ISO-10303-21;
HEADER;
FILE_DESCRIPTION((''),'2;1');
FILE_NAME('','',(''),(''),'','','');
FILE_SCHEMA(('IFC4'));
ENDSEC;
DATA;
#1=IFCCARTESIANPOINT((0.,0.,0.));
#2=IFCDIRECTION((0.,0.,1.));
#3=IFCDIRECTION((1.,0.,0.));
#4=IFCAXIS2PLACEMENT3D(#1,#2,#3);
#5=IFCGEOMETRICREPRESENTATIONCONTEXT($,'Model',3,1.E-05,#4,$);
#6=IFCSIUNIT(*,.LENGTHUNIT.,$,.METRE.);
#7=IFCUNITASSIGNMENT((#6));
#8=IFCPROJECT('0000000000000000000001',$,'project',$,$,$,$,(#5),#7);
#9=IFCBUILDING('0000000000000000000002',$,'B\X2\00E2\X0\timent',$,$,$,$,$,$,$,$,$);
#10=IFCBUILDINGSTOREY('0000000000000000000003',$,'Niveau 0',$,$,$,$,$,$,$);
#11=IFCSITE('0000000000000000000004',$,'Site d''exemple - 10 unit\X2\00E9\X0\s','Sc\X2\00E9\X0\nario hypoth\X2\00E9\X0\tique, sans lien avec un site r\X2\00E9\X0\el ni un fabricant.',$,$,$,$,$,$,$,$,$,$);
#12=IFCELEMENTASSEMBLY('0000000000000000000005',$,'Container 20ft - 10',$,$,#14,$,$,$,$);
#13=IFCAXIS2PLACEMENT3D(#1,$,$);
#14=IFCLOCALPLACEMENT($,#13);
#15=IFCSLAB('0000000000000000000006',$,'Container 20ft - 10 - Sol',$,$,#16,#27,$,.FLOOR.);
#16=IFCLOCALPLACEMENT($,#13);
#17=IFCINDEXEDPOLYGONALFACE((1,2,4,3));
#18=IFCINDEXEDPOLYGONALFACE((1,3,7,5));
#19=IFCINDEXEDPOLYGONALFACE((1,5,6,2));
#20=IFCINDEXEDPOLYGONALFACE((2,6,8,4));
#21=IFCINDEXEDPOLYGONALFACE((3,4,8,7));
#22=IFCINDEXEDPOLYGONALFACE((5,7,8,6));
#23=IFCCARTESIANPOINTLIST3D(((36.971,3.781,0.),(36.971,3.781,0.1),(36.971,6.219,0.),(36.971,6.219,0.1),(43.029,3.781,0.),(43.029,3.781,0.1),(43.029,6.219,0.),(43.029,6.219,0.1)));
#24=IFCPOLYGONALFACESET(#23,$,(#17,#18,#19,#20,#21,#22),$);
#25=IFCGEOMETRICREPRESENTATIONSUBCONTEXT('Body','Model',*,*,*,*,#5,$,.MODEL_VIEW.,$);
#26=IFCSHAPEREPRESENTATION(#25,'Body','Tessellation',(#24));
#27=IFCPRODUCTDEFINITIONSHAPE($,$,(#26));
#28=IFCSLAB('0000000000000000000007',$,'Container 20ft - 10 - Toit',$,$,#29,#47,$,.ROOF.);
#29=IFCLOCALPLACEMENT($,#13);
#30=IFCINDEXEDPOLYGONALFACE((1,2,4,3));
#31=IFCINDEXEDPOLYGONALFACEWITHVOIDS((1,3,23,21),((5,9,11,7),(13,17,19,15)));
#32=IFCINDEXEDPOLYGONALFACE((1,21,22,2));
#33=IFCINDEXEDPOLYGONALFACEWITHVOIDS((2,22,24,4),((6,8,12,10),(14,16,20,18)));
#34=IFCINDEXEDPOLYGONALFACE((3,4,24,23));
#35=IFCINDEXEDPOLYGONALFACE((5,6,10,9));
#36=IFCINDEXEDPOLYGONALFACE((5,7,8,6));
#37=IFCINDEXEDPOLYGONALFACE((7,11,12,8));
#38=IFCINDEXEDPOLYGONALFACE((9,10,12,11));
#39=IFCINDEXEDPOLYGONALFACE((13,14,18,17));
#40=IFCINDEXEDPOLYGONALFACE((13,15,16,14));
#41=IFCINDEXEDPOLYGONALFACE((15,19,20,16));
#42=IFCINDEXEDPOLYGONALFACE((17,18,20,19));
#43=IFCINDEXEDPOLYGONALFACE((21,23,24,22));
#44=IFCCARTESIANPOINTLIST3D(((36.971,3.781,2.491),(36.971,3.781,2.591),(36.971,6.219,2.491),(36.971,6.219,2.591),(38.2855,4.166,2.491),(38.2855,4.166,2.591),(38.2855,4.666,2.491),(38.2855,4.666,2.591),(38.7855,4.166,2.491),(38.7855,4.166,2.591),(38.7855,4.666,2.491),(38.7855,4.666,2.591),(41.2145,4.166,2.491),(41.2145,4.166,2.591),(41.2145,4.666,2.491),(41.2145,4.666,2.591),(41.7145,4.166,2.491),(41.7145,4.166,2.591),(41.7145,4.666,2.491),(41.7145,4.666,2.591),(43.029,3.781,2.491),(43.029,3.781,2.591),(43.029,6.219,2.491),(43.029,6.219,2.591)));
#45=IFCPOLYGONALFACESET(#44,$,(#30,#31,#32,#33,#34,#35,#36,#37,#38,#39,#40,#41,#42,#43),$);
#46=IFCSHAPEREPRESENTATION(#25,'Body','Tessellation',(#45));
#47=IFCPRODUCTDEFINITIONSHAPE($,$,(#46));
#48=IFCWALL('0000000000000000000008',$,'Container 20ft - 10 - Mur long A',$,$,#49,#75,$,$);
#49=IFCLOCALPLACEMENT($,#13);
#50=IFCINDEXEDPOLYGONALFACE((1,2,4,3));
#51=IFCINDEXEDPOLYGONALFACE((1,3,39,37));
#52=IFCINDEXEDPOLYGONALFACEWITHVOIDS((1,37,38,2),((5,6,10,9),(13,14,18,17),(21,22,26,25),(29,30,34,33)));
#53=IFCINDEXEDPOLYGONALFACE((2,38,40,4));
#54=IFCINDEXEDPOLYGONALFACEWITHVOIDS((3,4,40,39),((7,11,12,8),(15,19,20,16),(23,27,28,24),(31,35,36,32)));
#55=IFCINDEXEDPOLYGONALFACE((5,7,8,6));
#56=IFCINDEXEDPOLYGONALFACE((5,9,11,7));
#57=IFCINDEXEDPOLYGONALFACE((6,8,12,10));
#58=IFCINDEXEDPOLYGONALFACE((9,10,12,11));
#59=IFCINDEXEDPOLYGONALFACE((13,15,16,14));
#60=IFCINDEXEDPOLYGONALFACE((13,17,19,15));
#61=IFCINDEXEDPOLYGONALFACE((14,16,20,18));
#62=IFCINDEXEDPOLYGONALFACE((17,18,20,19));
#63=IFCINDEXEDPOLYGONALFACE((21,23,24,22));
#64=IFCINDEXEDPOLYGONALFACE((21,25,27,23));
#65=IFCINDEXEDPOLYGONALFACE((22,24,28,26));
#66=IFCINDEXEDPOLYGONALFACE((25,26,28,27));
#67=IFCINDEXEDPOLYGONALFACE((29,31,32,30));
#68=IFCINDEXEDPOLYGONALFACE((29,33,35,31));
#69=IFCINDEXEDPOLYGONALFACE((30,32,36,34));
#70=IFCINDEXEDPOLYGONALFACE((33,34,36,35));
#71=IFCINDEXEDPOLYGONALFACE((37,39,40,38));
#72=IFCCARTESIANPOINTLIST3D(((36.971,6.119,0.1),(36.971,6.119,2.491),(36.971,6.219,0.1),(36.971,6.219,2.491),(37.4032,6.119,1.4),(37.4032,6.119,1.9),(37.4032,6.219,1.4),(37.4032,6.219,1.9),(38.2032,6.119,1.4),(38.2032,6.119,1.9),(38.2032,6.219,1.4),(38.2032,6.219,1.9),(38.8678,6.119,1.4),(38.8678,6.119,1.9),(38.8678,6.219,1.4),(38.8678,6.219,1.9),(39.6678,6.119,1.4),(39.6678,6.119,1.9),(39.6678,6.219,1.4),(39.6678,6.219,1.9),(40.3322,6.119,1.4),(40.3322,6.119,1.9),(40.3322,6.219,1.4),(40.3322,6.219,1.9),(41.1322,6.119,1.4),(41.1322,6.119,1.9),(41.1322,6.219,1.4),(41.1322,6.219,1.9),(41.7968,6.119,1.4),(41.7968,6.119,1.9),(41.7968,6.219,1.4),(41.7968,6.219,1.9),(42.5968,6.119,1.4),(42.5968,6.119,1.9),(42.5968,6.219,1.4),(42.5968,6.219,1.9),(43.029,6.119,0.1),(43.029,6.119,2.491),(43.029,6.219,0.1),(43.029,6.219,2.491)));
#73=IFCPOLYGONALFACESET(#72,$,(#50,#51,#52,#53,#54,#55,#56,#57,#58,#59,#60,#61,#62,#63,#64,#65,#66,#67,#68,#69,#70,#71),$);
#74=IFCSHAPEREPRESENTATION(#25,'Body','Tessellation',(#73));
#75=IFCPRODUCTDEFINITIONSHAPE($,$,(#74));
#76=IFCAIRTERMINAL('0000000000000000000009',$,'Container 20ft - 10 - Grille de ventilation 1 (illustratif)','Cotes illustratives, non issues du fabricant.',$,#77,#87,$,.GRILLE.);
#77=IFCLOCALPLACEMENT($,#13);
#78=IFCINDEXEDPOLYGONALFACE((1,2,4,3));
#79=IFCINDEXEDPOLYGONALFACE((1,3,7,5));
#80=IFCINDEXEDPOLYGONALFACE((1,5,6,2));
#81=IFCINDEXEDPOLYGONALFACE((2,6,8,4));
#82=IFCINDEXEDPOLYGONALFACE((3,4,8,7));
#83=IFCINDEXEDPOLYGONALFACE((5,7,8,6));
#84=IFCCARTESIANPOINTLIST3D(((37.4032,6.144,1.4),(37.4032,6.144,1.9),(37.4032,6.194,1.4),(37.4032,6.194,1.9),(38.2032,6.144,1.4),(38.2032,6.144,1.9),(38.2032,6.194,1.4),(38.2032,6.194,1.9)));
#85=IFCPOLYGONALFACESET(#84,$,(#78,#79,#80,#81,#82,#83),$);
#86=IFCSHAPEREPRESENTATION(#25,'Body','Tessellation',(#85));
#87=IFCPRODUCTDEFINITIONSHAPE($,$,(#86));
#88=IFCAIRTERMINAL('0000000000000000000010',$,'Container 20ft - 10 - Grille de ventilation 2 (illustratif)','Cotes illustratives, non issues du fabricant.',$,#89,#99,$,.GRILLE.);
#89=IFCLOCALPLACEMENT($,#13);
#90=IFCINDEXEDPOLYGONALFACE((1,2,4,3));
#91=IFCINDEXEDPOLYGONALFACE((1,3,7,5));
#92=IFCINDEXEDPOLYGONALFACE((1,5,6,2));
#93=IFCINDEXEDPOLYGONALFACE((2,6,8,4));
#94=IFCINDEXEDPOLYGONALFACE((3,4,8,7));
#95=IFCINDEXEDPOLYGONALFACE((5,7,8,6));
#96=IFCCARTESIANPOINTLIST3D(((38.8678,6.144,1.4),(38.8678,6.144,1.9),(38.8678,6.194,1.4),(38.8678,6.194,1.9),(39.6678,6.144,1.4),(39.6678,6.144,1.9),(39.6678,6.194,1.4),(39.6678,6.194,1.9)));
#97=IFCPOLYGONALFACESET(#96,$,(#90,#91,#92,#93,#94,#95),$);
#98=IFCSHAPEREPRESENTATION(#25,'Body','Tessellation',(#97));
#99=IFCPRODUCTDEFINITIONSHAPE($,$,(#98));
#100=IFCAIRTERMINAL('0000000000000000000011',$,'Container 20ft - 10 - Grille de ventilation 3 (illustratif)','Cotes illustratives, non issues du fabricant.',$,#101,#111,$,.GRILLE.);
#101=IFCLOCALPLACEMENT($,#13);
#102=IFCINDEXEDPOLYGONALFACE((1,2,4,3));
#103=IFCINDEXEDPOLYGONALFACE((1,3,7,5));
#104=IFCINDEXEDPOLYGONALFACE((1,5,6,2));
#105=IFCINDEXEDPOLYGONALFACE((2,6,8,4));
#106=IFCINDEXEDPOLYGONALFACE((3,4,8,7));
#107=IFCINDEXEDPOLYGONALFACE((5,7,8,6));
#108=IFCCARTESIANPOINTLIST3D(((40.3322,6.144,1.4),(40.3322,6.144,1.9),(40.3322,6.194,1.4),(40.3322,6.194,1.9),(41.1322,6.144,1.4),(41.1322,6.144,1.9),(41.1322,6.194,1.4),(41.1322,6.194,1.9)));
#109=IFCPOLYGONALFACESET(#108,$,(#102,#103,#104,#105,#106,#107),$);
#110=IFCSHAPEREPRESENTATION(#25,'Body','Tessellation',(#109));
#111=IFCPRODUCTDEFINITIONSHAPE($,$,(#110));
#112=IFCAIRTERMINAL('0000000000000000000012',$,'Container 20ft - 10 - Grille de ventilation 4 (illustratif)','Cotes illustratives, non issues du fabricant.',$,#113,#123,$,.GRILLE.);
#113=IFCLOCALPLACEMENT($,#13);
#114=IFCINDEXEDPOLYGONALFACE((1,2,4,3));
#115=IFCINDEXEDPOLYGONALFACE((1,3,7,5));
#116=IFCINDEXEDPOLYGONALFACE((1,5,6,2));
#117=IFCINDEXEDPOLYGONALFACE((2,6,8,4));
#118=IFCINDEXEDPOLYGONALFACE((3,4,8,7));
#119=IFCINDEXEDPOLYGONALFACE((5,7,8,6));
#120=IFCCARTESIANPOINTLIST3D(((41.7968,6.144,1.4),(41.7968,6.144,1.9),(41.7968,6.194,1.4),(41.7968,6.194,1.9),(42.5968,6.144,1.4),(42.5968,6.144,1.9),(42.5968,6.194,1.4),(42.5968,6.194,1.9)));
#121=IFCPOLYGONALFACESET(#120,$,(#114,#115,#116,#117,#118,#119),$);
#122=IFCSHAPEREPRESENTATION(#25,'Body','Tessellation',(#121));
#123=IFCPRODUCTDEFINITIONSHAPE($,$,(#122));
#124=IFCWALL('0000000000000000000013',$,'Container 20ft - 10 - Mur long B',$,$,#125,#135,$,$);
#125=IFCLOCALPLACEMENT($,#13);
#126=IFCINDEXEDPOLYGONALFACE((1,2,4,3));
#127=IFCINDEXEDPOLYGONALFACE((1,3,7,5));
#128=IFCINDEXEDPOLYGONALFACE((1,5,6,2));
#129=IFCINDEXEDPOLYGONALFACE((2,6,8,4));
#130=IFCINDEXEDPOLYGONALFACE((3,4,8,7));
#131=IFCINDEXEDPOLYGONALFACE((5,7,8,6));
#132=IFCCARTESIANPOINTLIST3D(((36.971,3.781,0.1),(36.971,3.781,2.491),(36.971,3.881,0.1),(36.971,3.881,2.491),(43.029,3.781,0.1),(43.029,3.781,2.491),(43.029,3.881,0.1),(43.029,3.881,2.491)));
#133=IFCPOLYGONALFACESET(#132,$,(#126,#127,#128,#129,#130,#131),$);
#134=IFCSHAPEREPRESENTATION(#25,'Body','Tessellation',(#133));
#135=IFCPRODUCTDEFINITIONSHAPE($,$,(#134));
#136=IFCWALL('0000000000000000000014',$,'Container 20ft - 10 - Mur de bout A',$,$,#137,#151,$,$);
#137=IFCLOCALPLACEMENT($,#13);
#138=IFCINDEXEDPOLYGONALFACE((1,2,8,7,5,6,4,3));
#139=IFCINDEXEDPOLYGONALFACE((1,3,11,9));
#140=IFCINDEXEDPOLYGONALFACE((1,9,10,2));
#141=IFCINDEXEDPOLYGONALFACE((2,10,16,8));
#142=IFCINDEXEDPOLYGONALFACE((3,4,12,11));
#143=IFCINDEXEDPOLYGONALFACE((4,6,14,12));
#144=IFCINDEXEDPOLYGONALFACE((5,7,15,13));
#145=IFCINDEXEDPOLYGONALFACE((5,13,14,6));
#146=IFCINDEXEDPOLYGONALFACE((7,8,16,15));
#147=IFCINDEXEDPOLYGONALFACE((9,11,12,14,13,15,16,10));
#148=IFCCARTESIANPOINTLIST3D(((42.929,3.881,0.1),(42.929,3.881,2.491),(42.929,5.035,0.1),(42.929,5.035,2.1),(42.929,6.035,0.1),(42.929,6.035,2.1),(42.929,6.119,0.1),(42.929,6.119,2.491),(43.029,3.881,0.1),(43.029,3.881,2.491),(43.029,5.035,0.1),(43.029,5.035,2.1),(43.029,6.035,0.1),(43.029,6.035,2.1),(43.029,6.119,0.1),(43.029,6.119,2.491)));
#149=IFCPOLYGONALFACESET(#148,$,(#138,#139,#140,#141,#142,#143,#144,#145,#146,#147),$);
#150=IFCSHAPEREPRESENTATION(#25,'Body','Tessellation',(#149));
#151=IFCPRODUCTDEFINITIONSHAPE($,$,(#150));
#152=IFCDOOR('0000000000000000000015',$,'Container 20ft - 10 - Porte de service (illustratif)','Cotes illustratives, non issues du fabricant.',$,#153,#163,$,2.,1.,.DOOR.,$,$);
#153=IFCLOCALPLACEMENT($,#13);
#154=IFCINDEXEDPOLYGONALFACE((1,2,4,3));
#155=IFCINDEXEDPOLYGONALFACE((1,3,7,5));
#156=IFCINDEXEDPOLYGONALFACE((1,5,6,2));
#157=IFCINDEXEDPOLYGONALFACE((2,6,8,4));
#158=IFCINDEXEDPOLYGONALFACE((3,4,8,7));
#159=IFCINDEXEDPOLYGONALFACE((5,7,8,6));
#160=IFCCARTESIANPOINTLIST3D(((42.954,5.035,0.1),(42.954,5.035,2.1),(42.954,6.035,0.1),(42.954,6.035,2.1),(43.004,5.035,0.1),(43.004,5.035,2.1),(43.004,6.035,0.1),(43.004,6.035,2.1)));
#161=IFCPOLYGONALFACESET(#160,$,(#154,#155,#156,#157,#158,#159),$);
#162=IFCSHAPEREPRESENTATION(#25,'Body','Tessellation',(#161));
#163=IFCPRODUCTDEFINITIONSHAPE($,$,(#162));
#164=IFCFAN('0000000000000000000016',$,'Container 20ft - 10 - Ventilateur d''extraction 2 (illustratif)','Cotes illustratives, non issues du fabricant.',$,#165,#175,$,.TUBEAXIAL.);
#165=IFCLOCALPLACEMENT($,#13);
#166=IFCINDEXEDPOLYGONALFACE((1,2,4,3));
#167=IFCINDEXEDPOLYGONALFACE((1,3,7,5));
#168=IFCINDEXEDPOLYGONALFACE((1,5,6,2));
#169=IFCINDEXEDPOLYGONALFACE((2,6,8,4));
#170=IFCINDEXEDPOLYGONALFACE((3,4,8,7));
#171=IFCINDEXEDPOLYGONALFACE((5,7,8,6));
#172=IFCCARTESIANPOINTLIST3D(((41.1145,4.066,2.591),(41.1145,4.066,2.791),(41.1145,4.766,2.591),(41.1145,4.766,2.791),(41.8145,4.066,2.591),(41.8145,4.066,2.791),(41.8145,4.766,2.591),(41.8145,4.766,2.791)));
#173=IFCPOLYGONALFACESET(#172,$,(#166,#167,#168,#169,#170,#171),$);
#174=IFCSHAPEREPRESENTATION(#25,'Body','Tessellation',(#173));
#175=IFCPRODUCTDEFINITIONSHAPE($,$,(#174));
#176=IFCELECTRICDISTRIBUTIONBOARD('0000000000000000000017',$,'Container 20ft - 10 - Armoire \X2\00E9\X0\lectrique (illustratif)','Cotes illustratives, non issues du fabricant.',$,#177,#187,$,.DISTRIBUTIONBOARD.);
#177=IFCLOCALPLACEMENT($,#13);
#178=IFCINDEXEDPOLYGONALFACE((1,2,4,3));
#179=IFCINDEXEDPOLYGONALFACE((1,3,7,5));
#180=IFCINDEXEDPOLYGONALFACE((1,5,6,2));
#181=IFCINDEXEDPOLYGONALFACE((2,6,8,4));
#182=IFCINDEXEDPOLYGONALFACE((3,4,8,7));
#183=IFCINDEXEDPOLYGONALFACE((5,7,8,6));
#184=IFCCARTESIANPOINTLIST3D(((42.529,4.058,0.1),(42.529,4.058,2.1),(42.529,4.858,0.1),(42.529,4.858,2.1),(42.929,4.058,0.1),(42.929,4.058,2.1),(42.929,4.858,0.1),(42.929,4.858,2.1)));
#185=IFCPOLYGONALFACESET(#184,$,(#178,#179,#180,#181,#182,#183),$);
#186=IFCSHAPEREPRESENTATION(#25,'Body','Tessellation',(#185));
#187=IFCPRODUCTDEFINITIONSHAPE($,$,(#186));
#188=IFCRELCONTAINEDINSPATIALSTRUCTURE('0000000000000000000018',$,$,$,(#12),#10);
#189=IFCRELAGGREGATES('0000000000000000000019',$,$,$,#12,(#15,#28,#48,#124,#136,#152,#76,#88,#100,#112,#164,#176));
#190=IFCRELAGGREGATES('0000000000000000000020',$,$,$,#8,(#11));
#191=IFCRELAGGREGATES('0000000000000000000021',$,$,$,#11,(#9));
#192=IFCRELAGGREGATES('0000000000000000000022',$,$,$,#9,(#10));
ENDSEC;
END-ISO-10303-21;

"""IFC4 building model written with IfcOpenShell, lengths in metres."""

from ifc_helpers import new_model, si_unit, frame, origin_with_axes, place, context, subcontext, project, spatial, rectangle, extrude, element, fill, aggregate, save


model = new_model("IFC4")

# Units and contexts
model_context = context("Model", 3, precision=1e-05, world=origin_with_axes())
body_context = subcontext(model_context, "Body", "Model", "MODEL_VIEW")
ifc_project = project(units=[si_unit("LENGTHUNIT", "METRE")], contexts=[model_context])

# Site, building, storey
site = spatial("IfcSite", under=ifc_project, Name="Site d'exemple - 10 unités", Description="Scénario hypothétique, sans lien avec un site réel ni un fabricant.")
building = spatial("IfcBuilding", under=site, Name="Bâtiment")
storey = spatial("IfcBuildingStorey", under=building, Name="Niveau 0")

# Element assembly, slabs, openings, walls, air terminals, door, fan, electric distribution board
assembly = element("IfcElementAssembly", 1, inside=storey, Name="Container 20ft - 10")
slab_1_placement = place(None, frame((40.0, 5.0, 0.0), z_axis=(0.0, 0.0, 1.0), x_axis=(1.0, 0.0, 0.0)))
slab_1 = element("IfcSlab", 2, at=slab_1_placement, Name="Container 20ft - 10 - Sol", PredefinedType="FLOOR", context=body_context, shape_type="SweptSolid", body=[
    extrude(rectangle(XDim=6.058, YDim=2.438), origin_with_axes(), (0.0, 0.0, 1.0), 0.1),
])
slab_2_placement = place(None, frame((40.0, 5.0, 2.491), z_axis=(0.0, 0.0, 1.0), x_axis=(1.0, 0.0, 0.0)))
slab_2 = element("IfcSlab", 3, at=slab_2_placement, Name="Container 20ft - 10 - Toit", PredefinedType="ROOF", context=body_context, shape_type="SweptSolid", body=[
    extrude(rectangle(XDim=6.058, YDim=2.438), origin_with_axes(), (0.0, 0.0, 1.0), 0.1),
])
opening_1_placement = place(None, frame((38.5355, 4.416, 2.441), z_axis=(0.0, 0.0, 1.0), x_axis=(1.0, 0.0, 0.0)))
element("IfcOpeningElement", 4, at=opening_1_placement, cuts=slab_2, PredefinedType="OPENING", context=body_context, shape_type="SweptSolid", body=[
    extrude(rectangle(XDim=0.5, YDim=0.5), origin_with_axes(), (0.0, 0.0, 1.0), 0.2),
])
opening_2_placement = place(None, frame((41.4645, 4.416, 2.441), z_axis=(0.0, 0.0, 1.0), x_axis=(1.0, 0.0, 0.0)))
element("IfcOpeningElement", 5, at=opening_2_placement, cuts=slab_2, PredefinedType="OPENING", context=body_context, shape_type="SweptSolid", body=[
    extrude(rectangle(XDim=0.5, YDim=0.5), origin_with_axes(), (0.0, 0.0, 1.0), 0.2),
])
wall_1_placement = place(None, frame((40.0, 6.169, 0.1), z_axis=(0.0, 0.0, 1.0), x_axis=(1.0, 0.0, 0.0)))
wall_1 = element("IfcWall", 6, at=wall_1_placement, Name="Container 20ft - 10 - Mur long A", context=body_context, shape_type="SweptSolid", body=[
    extrude(rectangle(XDim=6.058, YDim=0.1), origin_with_axes(), (0.0, 0.0, 1.0), 2.391),
])
opening_3_placement = place(None, frame((37.8032, 6.169, 1.4), z_axis=(0.0, 0.0, 1.0), x_axis=(1.0, 0.0, 0.0)))
opening_3 = element("IfcOpeningElement", 7, at=opening_3_placement, cuts=wall_1, PredefinedType="OPENING", context=body_context, shape_type="SweptSolid", body=[
    extrude(rectangle(XDim=0.8, YDim=0.2), origin_with_axes(), (0.0, 0.0, 1.0), 0.5),
])
opening_4_placement = place(None, frame((39.2677, 6.169, 1.4), z_axis=(0.0, 0.0, 1.0), x_axis=(1.0, 0.0, 0.0)))
opening_4 = element("IfcOpeningElement", 8, at=opening_4_placement, cuts=wall_1, PredefinedType="OPENING", context=body_context, shape_type="SweptSolid", body=[
    extrude(rectangle(XDim=0.8, YDim=0.2), origin_with_axes(), (0.0, 0.0, 1.0), 0.5),
])
opening_5_placement = place(None, frame((40.7323, 6.169, 1.4), z_axis=(0.0, 0.0, 1.0), x_axis=(1.0, 0.0, 0.0)))
opening_5 = element("IfcOpeningElement", 9, at=opening_5_placement, cuts=wall_1, PredefinedType="OPENING", context=body_context, shape_type="SweptSolid", body=[
    extrude(rectangle(XDim=0.8, YDim=0.2), origin_with_axes(), (0.0, 0.0, 1.0), 0.5),
])
opening_6_placement = place(None, frame((42.1968, 6.169, 1.4), z_axis=(0.0, 0.0, 1.0), x_axis=(1.0, 0.0, 0.0)))
opening_6 = element("IfcOpeningElement", 10, at=opening_6_placement, cuts=wall_1, PredefinedType="OPENING", context=body_context, shape_type="SweptSolid", body=[
    extrude(rectangle(XDim=0.8, YDim=0.2), origin_with_axes(), (0.0, 0.0, 1.0), 0.5),
])
air_terminal_1_placement = place(None, frame((37.8032, 6.169, 1.4), z_axis=(0.0, 0.0, 1.0), x_axis=(1.0, 0.0, 0.0)))
air_terminal_1 = element("IfcAirTerminal", 11, at=air_terminal_1_placement, Name="Container 20ft - 10 - Grille de ventilation 1 (illustratif)", Description="Cotes illustratives, non issues du fabricant.", PredefinedType="GRILLE", context=body_context, shape_type="SweptSolid", body=[
    extrude(rectangle(XDim=0.8, YDim=0.05), origin_with_axes(), (0.0, 0.0, 1.0), 0.5),
])
fill(opening_3, air_terminal_1)
air_terminal_2_placement = place(None, frame((39.2677, 6.169, 1.4), z_axis=(0.0, 0.0, 1.0), x_axis=(1.0, 0.0, 0.0)))
air_terminal_2 = element("IfcAirTerminal", 12, at=air_terminal_2_placement, Name="Container 20ft - 10 - Grille de ventilation 2 (illustratif)", Description="Cotes illustratives, non issues du fabricant.", PredefinedType="GRILLE", context=body_context, shape_type="SweptSolid", body=[
    extrude(rectangle(XDim=0.8, YDim=0.05), origin_with_axes(), (0.0, 0.0, 1.0), 0.5),
])
fill(opening_4, air_terminal_2)
air_terminal_3_placement = place(None, frame((40.7323, 6.169, 1.4), z_axis=(0.0, 0.0, 1.0), x_axis=(1.0, 0.0, 0.0)))
air_terminal_3 = element("IfcAirTerminal", 13, at=air_terminal_3_placement, Name="Container 20ft - 10 - Grille de ventilation 3 (illustratif)", Description="Cotes illustratives, non issues du fabricant.", PredefinedType="GRILLE", context=body_context, shape_type="SweptSolid", body=[
    extrude(rectangle(XDim=0.8, YDim=0.05), origin_with_axes(), (0.0, 0.0, 1.0), 0.5),
])
fill(opening_5, air_terminal_3)
air_terminal_4_placement = place(None, frame((42.1968, 6.169, 1.4), z_axis=(0.0, 0.0, 1.0), x_axis=(1.0, 0.0, 0.0)))
air_terminal_4 = element("IfcAirTerminal", 14, at=air_terminal_4_placement, Name="Container 20ft - 10 - Grille de ventilation 4 (illustratif)", Description="Cotes illustratives, non issues du fabricant.", PredefinedType="GRILLE", context=body_context, shape_type="SweptSolid", body=[
    extrude(rectangle(XDim=0.8, YDim=0.05), origin_with_axes(), (0.0, 0.0, 1.0), 0.5),
])
fill(opening_6, air_terminal_4)
wall_2_placement = place(None, frame((40.0, 3.831, 0.1), z_axis=(0.0, 0.0, 1.0), x_axis=(1.0, 0.0, 0.0)))
wall_2 = element("IfcWall", 15, at=wall_2_placement, Name="Container 20ft - 10 - Mur long B", context=body_context, shape_type="SweptSolid", body=[
    extrude(rectangle(XDim=6.058, YDim=0.1), origin_with_axes(), (0.0, 0.0, 1.0), 2.391),
])
wall_3_placement = place(None, frame((42.979, 5.0, 0.1), z_axis=(0.0, 0.0, 1.0), x_axis=(1.0, 0.0, 0.0)))
wall_3 = element("IfcWall", 16, at=wall_3_placement, Name="Container 20ft - 10 - Mur de bout A", context=body_context, shape_type="SweptSolid", body=[
    extrude(rectangle(XDim=0.1, YDim=2.238), origin_with_axes(), (0.0, 0.0, 1.0), 2.391),
])
opening_7_placement = place(None, frame((42.979, 5.535, 0.1), z_axis=(0.0, 0.0, 1.0), x_axis=(1.0, 0.0, 0.0)))
opening_7 = element("IfcOpeningElement", 17, at=opening_7_placement, cuts=wall_3, PredefinedType="OPENING", context=body_context, shape_type="SweptSolid", body=[
    extrude(rectangle(XDim=0.2, YDim=1.0), origin_with_axes(), (0.0, 0.0, 1.0), 2.0),
])
door_placement = place(None, frame((42.979, 5.535, 0.1), z_axis=(0.0, 0.0, 1.0), x_axis=(1.0, 0.0, 0.0)))
door = element("IfcDoor", 18, at=door_placement, Name="Container 20ft - 10 - Porte de service (illustratif)", Description="Cotes illustratives, non issues du fabricant.", OverallHeight=2.0, OverallWidth=1.0, PredefinedType="DOOR", context=body_context, shape_type="SweptSolid", body=[
    extrude(rectangle(XDim=0.05, YDim=1.0), origin_with_axes(), (0.0, 0.0, 1.0), 2.0),
])
fill(opening_7, door)
fan_placement = place(None, frame((41.4645, 4.416, 2.591), z_axis=(0.0, 0.0, 1.0), x_axis=(1.0, 0.0, 0.0)))
fan = element("IfcFan", 19, at=fan_placement, Name="Container 20ft - 10 - Ventilateur d'extraction 2 (illustratif)", Description="Cotes illustratives, non issues du fabricant.", PredefinedType="TUBEAXIAL", context=body_context, shape_type="SweptSolid", body=[
    extrude(rectangle(XDim=0.7, YDim=0.7), origin_with_axes(), (0.0, 0.0, 1.0), 0.2),
])
electric_distribution_board_placement = place(None, frame((42.729, 4.458, 0.1), z_axis=(0.0, 0.0, 1.0), x_axis=(1.0, 0.0, 0.0)))
electric_distribution_board = element("IfcElectricDistributionBoard", 20, at=electric_distribution_board_placement, Name="Container 20ft - 10 - Armoire électrique (illustratif)", Description="Cotes illustratives, non issues du fabricant.", PredefinedType="DISTRIBUTIONBOARD", context=body_context, shape_type="SweptSolid", body=[
    extrude(rectangle(XDim=0.4, YDim=0.8), origin_with_axes(), (0.0, 0.0, 1.0), 2.0),
])
aggregate(assembly, [slab_1, slab_2, wall_1, wall_2, wall_3, door, air_terminal_1, air_terminal_2, air_terminal_3, air_terminal_4, fan, electric_distribution_board])

save(model, "model.ifc")
